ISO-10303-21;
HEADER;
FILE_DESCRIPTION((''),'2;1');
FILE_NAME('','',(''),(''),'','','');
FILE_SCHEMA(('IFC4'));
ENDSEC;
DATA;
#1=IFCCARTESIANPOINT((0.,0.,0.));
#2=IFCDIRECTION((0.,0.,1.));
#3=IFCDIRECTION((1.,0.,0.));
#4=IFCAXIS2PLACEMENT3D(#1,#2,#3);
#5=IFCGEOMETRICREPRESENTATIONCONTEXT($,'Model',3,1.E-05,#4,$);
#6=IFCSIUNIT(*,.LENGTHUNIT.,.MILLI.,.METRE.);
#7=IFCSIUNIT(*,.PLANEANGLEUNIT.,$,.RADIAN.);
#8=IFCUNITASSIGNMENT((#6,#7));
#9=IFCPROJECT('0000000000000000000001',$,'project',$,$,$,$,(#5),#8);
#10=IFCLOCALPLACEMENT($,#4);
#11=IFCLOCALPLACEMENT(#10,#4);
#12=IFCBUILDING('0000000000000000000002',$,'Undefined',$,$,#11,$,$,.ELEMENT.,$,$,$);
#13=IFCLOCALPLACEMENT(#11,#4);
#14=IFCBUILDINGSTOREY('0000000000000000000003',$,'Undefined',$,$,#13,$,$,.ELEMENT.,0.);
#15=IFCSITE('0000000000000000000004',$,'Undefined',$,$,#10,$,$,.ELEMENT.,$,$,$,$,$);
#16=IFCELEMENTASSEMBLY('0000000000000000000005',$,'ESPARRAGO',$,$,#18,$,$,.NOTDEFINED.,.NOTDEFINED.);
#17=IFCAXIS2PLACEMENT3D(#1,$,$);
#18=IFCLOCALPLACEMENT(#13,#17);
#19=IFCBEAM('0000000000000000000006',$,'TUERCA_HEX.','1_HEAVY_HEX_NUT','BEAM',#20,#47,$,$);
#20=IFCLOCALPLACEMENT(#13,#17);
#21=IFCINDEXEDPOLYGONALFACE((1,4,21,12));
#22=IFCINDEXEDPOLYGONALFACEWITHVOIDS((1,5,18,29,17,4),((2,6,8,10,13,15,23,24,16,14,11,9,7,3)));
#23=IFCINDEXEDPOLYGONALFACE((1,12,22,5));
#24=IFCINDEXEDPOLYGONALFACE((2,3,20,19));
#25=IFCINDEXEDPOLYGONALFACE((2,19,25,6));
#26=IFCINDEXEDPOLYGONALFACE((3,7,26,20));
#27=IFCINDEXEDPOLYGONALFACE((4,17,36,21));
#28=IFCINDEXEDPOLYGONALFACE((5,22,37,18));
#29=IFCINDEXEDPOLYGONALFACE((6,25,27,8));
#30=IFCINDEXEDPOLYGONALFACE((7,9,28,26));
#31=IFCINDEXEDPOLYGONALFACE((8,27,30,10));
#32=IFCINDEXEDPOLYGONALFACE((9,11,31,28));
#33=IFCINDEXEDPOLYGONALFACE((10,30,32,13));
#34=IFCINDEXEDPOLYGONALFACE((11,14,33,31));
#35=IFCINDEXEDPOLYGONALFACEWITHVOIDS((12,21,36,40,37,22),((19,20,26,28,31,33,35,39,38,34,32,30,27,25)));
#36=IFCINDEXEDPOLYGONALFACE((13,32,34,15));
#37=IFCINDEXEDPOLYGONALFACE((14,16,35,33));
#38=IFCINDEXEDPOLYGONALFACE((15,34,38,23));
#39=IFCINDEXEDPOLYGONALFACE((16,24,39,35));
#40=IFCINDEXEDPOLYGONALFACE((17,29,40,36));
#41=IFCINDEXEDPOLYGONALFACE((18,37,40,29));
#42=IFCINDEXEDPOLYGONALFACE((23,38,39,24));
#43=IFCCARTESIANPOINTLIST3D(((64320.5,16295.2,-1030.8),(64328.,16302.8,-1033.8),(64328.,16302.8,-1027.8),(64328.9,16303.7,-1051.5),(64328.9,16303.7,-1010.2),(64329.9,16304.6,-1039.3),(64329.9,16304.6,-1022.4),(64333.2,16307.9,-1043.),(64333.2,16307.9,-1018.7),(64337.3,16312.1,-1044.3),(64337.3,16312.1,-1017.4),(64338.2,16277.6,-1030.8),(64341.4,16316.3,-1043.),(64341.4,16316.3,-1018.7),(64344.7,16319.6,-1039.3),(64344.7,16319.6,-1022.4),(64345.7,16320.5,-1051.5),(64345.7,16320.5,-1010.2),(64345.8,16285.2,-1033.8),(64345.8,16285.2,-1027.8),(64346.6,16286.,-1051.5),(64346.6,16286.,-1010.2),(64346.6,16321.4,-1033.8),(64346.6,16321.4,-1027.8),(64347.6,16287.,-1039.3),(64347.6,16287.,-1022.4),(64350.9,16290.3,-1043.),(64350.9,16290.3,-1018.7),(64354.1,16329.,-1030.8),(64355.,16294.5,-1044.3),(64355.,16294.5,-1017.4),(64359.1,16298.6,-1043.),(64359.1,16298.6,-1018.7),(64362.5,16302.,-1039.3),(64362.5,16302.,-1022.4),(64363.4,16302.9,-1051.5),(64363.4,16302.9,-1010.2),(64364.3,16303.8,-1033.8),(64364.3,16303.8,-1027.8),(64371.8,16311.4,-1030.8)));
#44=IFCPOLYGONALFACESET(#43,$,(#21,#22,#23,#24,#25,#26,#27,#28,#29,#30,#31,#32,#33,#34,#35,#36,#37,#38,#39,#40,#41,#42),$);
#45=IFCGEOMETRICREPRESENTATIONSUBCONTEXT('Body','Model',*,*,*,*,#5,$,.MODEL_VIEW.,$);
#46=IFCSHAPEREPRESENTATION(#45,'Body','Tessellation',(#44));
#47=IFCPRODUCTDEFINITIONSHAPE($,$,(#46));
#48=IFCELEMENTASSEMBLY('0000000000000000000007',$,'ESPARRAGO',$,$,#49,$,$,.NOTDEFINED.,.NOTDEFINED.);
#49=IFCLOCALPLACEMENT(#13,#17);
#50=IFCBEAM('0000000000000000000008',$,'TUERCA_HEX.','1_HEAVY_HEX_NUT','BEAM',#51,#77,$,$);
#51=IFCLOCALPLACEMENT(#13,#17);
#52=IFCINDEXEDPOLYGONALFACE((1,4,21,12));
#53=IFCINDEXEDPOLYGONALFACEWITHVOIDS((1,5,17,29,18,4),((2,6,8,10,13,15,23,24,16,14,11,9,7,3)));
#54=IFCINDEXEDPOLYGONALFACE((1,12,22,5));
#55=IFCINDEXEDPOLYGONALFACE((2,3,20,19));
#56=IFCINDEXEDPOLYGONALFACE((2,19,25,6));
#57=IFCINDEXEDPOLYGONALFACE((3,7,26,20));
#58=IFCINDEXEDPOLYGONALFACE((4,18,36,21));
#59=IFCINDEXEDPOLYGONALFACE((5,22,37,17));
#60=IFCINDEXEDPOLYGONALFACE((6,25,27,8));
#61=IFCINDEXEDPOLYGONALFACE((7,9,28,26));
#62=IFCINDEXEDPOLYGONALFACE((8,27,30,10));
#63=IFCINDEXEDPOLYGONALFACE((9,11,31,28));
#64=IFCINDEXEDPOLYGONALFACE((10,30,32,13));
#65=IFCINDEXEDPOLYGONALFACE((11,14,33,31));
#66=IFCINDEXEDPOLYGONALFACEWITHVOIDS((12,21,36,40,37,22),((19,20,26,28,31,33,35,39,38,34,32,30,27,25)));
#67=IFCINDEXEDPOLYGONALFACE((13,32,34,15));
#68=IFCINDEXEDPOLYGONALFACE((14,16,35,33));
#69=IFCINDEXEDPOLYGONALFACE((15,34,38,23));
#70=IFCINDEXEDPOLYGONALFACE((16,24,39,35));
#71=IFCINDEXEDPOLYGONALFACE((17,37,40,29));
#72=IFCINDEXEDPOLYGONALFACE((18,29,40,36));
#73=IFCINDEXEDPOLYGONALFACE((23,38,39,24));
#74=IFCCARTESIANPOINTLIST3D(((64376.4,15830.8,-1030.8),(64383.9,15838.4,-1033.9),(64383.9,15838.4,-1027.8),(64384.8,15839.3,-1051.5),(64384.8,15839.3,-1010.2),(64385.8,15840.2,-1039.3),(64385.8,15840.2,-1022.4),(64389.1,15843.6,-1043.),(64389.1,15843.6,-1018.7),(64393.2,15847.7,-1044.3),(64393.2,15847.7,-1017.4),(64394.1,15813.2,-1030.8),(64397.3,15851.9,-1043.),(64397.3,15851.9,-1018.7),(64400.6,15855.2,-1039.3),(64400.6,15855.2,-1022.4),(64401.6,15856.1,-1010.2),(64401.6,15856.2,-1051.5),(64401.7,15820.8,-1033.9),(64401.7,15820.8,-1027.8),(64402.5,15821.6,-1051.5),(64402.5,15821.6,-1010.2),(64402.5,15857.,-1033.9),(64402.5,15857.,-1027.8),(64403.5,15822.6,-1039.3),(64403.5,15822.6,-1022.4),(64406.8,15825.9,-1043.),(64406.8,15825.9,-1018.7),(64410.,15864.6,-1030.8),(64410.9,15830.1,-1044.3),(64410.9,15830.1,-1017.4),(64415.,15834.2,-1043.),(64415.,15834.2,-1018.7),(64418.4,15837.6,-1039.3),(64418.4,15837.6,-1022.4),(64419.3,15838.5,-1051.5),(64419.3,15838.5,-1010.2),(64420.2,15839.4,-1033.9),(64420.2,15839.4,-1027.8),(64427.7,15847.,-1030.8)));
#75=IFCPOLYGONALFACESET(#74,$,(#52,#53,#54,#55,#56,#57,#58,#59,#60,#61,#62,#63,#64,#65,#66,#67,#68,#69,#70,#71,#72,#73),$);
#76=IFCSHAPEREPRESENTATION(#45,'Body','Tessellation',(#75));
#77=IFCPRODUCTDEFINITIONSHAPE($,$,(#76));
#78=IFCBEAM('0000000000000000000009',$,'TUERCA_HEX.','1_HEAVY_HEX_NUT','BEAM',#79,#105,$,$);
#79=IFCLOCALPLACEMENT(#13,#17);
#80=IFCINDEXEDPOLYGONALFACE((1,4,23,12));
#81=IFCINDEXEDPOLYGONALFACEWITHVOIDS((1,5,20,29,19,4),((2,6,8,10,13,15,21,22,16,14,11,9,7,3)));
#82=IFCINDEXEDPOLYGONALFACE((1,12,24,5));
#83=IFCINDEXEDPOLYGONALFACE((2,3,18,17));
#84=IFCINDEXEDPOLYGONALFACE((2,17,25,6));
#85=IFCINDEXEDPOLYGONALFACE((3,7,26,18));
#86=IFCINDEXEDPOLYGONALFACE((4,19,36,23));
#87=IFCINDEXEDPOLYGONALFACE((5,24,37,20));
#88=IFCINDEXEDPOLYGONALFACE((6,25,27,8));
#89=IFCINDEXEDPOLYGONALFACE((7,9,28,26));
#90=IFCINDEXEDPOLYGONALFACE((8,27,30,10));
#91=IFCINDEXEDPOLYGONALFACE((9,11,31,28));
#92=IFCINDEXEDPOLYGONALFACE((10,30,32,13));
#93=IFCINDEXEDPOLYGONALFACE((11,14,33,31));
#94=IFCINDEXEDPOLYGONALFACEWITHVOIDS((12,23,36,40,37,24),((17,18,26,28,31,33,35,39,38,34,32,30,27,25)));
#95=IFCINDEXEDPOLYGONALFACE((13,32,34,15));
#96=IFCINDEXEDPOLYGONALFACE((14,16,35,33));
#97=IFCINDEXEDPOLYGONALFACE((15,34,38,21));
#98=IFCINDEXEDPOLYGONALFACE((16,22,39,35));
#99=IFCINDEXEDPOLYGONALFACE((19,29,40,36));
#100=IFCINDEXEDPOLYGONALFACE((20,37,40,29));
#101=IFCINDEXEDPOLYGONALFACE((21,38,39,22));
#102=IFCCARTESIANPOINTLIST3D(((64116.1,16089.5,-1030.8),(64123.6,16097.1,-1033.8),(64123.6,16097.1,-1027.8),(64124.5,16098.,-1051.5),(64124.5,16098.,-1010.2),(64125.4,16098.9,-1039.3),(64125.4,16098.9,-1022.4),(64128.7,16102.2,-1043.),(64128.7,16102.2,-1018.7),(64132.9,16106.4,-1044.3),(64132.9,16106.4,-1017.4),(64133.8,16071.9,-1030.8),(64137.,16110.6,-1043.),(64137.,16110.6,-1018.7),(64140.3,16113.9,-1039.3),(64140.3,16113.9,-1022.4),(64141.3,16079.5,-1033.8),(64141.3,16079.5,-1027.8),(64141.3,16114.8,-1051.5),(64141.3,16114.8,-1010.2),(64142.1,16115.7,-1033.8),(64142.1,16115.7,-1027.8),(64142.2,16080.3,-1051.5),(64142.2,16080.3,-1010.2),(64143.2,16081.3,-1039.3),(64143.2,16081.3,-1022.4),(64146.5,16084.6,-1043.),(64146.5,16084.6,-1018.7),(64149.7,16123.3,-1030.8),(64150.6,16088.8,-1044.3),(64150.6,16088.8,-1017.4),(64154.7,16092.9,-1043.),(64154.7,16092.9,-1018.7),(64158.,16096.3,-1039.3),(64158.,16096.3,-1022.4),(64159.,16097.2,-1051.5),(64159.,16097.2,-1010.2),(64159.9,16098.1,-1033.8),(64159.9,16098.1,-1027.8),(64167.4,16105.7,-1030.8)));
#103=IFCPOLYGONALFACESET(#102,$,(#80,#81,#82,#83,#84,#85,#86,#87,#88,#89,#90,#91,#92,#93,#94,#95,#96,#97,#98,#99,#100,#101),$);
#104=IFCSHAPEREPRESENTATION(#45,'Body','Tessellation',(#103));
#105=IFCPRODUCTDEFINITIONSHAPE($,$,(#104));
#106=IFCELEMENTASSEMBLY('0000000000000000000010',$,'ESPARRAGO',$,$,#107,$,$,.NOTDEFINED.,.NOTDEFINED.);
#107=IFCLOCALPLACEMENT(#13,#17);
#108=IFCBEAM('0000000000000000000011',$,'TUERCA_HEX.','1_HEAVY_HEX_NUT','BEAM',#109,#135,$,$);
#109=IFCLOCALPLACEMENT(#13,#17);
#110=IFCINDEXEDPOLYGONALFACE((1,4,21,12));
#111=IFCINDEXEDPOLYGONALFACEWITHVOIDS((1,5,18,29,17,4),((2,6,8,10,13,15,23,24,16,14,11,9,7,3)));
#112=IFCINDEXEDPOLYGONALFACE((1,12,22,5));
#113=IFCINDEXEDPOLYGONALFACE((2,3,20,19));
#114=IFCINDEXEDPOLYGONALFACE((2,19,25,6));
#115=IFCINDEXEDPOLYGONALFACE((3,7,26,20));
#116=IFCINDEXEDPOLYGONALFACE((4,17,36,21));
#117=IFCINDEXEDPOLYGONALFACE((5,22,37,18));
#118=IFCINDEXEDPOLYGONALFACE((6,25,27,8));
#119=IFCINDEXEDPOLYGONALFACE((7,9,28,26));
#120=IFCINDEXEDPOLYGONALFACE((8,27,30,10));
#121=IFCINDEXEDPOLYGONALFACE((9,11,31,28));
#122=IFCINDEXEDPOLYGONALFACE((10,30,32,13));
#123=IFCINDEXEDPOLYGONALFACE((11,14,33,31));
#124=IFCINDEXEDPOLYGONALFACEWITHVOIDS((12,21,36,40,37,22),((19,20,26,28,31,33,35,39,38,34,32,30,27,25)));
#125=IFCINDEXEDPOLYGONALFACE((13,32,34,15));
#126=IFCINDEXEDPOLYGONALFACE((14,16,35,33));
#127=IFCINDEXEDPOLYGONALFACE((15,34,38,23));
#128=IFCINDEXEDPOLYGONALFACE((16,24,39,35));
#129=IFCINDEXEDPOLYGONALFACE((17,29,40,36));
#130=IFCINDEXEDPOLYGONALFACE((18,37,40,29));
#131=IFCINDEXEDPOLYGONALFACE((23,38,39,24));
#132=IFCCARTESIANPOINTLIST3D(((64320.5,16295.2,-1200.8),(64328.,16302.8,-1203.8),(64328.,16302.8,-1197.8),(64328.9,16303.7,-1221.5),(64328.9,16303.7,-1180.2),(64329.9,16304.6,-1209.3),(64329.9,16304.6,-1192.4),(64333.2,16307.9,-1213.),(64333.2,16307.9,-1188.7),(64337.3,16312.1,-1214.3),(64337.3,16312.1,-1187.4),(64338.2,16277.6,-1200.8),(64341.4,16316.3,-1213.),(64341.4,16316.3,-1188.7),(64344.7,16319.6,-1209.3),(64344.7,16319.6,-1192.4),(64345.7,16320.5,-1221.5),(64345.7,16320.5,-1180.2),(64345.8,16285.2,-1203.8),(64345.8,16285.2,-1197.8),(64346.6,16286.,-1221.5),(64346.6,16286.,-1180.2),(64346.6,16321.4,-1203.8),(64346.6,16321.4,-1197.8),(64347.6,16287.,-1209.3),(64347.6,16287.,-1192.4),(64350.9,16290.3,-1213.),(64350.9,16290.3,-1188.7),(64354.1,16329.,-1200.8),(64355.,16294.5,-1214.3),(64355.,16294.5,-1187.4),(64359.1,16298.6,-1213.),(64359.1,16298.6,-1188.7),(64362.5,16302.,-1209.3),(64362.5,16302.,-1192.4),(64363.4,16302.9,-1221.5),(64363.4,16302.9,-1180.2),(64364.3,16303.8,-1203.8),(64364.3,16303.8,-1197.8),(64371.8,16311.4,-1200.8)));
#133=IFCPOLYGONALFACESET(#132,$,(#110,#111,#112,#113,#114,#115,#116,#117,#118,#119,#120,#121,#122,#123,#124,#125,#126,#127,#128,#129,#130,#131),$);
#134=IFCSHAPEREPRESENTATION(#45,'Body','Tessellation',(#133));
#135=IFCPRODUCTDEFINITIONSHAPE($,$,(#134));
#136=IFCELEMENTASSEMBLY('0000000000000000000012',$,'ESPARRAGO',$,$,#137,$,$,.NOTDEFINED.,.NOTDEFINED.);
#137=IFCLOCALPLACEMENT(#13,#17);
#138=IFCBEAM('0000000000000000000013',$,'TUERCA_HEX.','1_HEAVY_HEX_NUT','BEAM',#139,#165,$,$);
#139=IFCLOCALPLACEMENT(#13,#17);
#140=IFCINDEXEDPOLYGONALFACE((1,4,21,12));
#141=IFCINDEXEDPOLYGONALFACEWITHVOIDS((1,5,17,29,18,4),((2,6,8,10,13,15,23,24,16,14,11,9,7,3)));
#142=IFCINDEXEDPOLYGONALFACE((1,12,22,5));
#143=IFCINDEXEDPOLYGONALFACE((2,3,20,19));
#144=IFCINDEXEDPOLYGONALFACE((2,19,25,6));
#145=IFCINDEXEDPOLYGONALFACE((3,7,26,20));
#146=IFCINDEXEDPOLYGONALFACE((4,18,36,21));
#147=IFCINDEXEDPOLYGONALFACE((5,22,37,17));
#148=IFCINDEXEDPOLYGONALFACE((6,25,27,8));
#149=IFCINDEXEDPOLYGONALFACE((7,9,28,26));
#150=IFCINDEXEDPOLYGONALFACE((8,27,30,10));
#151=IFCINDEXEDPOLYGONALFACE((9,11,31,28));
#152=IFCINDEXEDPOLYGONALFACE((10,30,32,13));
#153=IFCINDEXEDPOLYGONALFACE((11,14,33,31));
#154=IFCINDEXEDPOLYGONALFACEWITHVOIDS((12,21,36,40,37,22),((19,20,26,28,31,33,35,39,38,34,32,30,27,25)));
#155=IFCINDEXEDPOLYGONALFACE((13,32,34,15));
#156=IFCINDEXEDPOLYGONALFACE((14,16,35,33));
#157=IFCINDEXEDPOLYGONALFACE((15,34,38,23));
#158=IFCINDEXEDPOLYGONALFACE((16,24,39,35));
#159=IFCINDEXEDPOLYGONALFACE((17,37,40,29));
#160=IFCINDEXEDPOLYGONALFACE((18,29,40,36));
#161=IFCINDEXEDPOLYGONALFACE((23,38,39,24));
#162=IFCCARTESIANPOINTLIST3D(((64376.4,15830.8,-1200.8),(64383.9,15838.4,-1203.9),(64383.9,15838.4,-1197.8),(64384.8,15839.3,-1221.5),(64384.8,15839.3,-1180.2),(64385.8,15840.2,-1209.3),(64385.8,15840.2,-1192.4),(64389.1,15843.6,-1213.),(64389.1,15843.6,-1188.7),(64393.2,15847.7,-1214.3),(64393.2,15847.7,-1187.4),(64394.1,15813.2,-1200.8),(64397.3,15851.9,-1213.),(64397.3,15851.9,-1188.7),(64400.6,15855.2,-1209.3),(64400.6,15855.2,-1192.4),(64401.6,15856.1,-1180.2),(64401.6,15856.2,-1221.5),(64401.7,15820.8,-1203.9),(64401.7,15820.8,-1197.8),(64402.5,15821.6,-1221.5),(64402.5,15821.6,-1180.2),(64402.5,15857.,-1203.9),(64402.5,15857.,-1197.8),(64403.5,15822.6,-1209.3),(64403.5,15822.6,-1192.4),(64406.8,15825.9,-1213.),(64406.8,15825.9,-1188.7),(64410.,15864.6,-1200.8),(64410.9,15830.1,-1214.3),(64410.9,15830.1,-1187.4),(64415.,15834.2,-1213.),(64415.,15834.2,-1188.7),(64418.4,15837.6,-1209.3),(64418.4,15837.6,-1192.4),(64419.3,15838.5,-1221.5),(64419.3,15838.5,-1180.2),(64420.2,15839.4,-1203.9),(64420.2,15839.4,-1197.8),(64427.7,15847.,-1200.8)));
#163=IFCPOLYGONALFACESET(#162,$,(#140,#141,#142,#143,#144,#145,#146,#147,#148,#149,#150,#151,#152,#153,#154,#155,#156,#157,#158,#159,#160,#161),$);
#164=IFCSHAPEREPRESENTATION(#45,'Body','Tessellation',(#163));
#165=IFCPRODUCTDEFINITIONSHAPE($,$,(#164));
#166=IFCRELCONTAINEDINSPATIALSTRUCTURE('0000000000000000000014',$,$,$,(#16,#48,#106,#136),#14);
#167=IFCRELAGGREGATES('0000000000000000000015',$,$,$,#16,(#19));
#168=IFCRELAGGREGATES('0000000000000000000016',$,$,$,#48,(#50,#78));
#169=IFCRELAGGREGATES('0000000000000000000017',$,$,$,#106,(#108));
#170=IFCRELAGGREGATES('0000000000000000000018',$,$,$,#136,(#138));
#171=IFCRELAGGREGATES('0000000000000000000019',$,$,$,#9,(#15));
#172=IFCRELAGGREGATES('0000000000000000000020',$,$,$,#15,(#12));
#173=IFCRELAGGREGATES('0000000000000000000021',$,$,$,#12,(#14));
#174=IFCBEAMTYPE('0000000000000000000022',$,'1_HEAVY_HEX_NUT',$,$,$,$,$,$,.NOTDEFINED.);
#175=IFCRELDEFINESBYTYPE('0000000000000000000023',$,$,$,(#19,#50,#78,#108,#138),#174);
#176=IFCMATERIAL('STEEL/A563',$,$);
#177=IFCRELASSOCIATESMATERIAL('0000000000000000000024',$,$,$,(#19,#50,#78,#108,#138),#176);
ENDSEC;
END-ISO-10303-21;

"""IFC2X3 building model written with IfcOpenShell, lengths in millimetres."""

from ifc_helpers import new_model, si_unit, frame, origin_with_axes, place, context, subcontext, project, spatial, polyline, outline, extrude, material, type_object, element, aggregate, save


model = new_model("IFC2X3")

# Units and contexts
model_context = context("Model", 3, precision=1e-05, world=origin_with_axes())
body_context = subcontext(model_context, "Body", "Model", "MODEL_VIEW")
ifc_project = project(units=[si_unit("LENGTHUNIT", "METRE", prefix="MILLI"), si_unit("PLANEANGLEUNIT", "RADIAN")], contexts=[model_context])

# Site, building, storey
site_placement = place(None, origin_with_axes())
site = spatial("IfcSite", under=ifc_project, at=site_placement, Name="Undefined", CompositionType="ELEMENT")
building_placement = place(site_placement, origin_with_axes())
building = spatial("IfcBuilding", under=site, at=building_placement, Name="Undefined", CompositionType="ELEMENT")
storey_placement = place(building_placement, origin_with_axes())
storey = spatial("IfcBuildingStorey", under=building, at=storey_placement, Name="Undefined", CompositionType="ELEMENT", Elevation=0.0)

# Element assemblies, beams
ifc_material_1 = material(Name="STEEL/A563")
beam_type_1 = type_object("IfcBeamType", Name="1_HEAVY_HEX_NUT", PredefinedType="NOTDEFINED")
assembly_1_placement = place(storey_placement, origin_with_axes())
assembly_1 = element("IfcElementAssembly", 1, at=assembly_1_placement, inside=storey, Name="ESPARRAGO", AssemblyPlace="NOTDEFINED", PredefinedType="NOTDEFINED")
beam_1_placement = place(assembly_1_placement, frame((64337.3, 16312.1, -1030.8), z_axis=(0.00001, -0.00001, 1.0), x_axis=(0.709311, -0.704895, -0.000014)))
beam_1 = element("IfcBeam", 2, at=beam_1_placement, type_object=beam_type_1, material=ifc_material_1, Name="TUERCA_HEX.", Description="1_HEAVY_HEX_NUT", ObjectType="BEAM", context=body_context, shape_type="SweptSolid", body=[
    extrude(outline(polyline([(11.9, -20.6), (-11.9, -20.6), (-23.8, 0.0), (-11.9, 20.6), (11.9, 20.6), (23.8, 0.0), (11.9, -20.6)]), holes=[polyline([(-5.9, 12.2), (-10.5, 8.4), (-13.2, 3.0), (-13.2, -3.0), (-10.5, -8.4), (-5.9, -12.2), (0.0, -13.5), (5.9, -12.2), (10.5, -8.4), (13.2, -3.0), (13.2, 3.0), (10.5, 8.4), (5.9, 12.2), (0.0, 13.5), (-5.9, 12.2)])]), frame((25.0, 0.0, 0.0), z_axis=(-1.0, 0.0, 0.0), x_axis=(0.0, -1.0, 0.0)), (0.0, 0.0, 1.0), 25.0),
])
assembly_2_placement = place(storey_placement, origin_with_axes())
assembly_2 = element("IfcElementAssembly", 3, at=assembly_2_placement, inside=storey, Name="ESPARRAGO", AssemblyPlace="NOTDEFINED", PredefinedType="NOTDEFINED")
beam_2_placement = place(assembly_2_placement, frame((64393.2, 15847.7, -1030.8), z_axis=(0.00001, -0.00001, 1.0), x_axis=(0.709311, -0.704895, -0.000014)))
beam_2 = element("IfcBeam", 4, at=beam_2_placement, type_object=beam_type_1, material=ifc_material_1, Name="TUERCA_HEX.", Description="1_HEAVY_HEX_NUT", ObjectType="BEAM", context=body_context, shape_type="SweptSolid", body=[
    extrude(outline(polyline([(11.9, -20.6), (-11.9, -20.6), (-23.8, 0.0), (-11.9, 20.6), (11.9, 20.6), (23.8, 0.0), (11.9, -20.6)]), holes=[polyline([(-5.9, 12.2), (-10.5, 8.4), (-13.2, 3.0), (-13.2, -3.0), (-10.5, -8.4), (-5.9, -12.2), (0.0, -13.5), (5.9, -12.2), (10.5, -8.4), (13.2, -3.0), (13.2, 3.0), (10.5, 8.4), (5.9, 12.2), (0.0, 13.5), (-5.9, 12.2)])]), frame((25.0, 0.0, 0.0), z_axis=(-1.0, 0.0, 0.0), x_axis=(0.0, -1.0, 0.0)), (0.0, 0.0, 1.0), 25.0),
])
beam_3_placement = place(assembly_2_placement, frame((64132.9, 16106.4, -1030.8), z_axis=(0.00001, -0.00001, 1.0), x_axis=(0.709311, -0.704895, -0.000014)))
beam_3 = element("IfcBeam", 5, at=beam_3_placement, type_object=beam_type_1, material=ifc_material_1, Name="TUERCA_HEX.", Description="1_HEAVY_HEX_NUT", ObjectType="BEAM", context=body_context, shape_type="SweptSolid", body=[
    extrude(outline(polyline([(11.9, -20.6), (-11.9, -20.6), (-23.8, 0.0), (-11.9, 20.6), (11.9, 20.6), (23.8, 0.0), (11.9, -20.6)]), holes=[polyline([(-5.9, 12.2), (-10.5, 8.4), (-13.2, 3.0), (-13.2, -3.0), (-10.5, -8.4), (-5.9, -12.2), (0.0, -13.5), (5.9, -12.2), (10.5, -8.4), (13.2, -3.0), (13.2, 3.0), (10.5, 8.4), (5.9, 12.2), (0.0, 13.5), (-5.9, 12.2)])]), frame((25.0, 0.0, 0.0), z_axis=(-1.0, 0.0, 0.0), x_axis=(0.0, -1.0, 0.0)), (0.0, 0.0, 1.0), 25.0),
])

# Element assembly, beam
assembly_3_placement = place(storey_placement, origin_with_axes())
assembly_3 = element("IfcElementAssembly", 6, at=assembly_3_placement, inside=storey, Name="ESPARRAGO", AssemblyPlace="NOTDEFINED", PredefinedType="NOTDEFINED")
beam_4_placement = place(assembly_3_placement, frame((64337.3, 16312.1, -1200.8), z_axis=(0.00001, -0.00001, 1.0), x_axis=(0.709311, -0.704895, -0.000014)))
beam_4 = element("IfcBeam", 7, at=beam_4_placement, type_object=beam_type_1, material=ifc_material_1, Name="TUERCA_HEX.", Description="1_HEAVY_HEX_NUT", ObjectType="BEAM", context=body_context, shape_type="SweptSolid", body=[
    extrude(outline(polyline([(11.9, -20.6), (-11.9, -20.6), (-23.8, 0.0), (-11.9, 20.6), (11.9, 20.6), (23.8, 0.0), (11.9, -20.6)]), holes=[polyline([(-5.9, 12.2), (-10.5, 8.4), (-13.2, 3.0), (-13.2, -3.0), (-10.5, -8.4), (-5.9, -12.2), (0.0, -13.5), (5.9, -12.2), (10.5, -8.4), (13.2, -3.0), (13.2, 3.0), (10.5, 8.4), (5.9, 12.2), (0.0, 13.5), (-5.9, 12.2)])]), frame((25.0, 0.0, 0.0), z_axis=(-1.0, 0.0, 0.0), x_axis=(0.0, -1.0, 0.0)), (0.0, 0.0, 1.0), 25.0),
])

# Element assembly, beam
assembly_4_placement = place(storey_placement, origin_with_axes())
assembly_4 = element("IfcElementAssembly", 8, at=assembly_4_placement, inside=storey, Name="ESPARRAGO", AssemblyPlace="NOTDEFINED", PredefinedType="NOTDEFINED")
beam_5_placement = place(assembly_4_placement, frame((64393.2, 15847.7, -1200.8), z_axis=(0.00001, -0.00001, 1.0), x_axis=(0.709311, -0.704895, -0.000014)))
beam_5 = element("IfcBeam", 9, at=beam_5_placement, type_object=beam_type_1, material=ifc_material_1, Name="TUERCA_HEX.", Description="1_HEAVY_HEX_NUT", ObjectType="BEAM", context=body_context, shape_type="SweptSolid", body=[
    extrude(outline(polyline([(11.9, -20.6), (-11.9, -20.6), (-23.8, 0.0), (-11.9, 20.6), (11.9, 20.6), (23.8, 0.0), (11.9, -20.6)]), holes=[polyline([(-5.9, 12.2), (-10.5, 8.4), (-13.2, 3.0), (-13.2, -3.0), (-10.5, -8.4), (-5.9, -12.2), (0.0, -13.5), (5.9, -12.2), (10.5, -8.4), (13.2, -3.0), (13.2, 3.0), (10.5, 8.4), (5.9, 12.2), (0.0, 13.5), (-5.9, 12.2)])]), frame((25.0, 0.0, 0.0), z_axis=(-1.0, 0.0, 0.0), x_axis=(0.0, -1.0, 0.0)), (0.0, 0.0, 1.0), 25.0),
])

aggregate(assembly_1, [beam_1])
aggregate(assembly_2, [beam_2, beam_3])
aggregate(assembly_3, [beam_4])
aggregate(assembly_4, [beam_5])

save(model, "model.ifc")
